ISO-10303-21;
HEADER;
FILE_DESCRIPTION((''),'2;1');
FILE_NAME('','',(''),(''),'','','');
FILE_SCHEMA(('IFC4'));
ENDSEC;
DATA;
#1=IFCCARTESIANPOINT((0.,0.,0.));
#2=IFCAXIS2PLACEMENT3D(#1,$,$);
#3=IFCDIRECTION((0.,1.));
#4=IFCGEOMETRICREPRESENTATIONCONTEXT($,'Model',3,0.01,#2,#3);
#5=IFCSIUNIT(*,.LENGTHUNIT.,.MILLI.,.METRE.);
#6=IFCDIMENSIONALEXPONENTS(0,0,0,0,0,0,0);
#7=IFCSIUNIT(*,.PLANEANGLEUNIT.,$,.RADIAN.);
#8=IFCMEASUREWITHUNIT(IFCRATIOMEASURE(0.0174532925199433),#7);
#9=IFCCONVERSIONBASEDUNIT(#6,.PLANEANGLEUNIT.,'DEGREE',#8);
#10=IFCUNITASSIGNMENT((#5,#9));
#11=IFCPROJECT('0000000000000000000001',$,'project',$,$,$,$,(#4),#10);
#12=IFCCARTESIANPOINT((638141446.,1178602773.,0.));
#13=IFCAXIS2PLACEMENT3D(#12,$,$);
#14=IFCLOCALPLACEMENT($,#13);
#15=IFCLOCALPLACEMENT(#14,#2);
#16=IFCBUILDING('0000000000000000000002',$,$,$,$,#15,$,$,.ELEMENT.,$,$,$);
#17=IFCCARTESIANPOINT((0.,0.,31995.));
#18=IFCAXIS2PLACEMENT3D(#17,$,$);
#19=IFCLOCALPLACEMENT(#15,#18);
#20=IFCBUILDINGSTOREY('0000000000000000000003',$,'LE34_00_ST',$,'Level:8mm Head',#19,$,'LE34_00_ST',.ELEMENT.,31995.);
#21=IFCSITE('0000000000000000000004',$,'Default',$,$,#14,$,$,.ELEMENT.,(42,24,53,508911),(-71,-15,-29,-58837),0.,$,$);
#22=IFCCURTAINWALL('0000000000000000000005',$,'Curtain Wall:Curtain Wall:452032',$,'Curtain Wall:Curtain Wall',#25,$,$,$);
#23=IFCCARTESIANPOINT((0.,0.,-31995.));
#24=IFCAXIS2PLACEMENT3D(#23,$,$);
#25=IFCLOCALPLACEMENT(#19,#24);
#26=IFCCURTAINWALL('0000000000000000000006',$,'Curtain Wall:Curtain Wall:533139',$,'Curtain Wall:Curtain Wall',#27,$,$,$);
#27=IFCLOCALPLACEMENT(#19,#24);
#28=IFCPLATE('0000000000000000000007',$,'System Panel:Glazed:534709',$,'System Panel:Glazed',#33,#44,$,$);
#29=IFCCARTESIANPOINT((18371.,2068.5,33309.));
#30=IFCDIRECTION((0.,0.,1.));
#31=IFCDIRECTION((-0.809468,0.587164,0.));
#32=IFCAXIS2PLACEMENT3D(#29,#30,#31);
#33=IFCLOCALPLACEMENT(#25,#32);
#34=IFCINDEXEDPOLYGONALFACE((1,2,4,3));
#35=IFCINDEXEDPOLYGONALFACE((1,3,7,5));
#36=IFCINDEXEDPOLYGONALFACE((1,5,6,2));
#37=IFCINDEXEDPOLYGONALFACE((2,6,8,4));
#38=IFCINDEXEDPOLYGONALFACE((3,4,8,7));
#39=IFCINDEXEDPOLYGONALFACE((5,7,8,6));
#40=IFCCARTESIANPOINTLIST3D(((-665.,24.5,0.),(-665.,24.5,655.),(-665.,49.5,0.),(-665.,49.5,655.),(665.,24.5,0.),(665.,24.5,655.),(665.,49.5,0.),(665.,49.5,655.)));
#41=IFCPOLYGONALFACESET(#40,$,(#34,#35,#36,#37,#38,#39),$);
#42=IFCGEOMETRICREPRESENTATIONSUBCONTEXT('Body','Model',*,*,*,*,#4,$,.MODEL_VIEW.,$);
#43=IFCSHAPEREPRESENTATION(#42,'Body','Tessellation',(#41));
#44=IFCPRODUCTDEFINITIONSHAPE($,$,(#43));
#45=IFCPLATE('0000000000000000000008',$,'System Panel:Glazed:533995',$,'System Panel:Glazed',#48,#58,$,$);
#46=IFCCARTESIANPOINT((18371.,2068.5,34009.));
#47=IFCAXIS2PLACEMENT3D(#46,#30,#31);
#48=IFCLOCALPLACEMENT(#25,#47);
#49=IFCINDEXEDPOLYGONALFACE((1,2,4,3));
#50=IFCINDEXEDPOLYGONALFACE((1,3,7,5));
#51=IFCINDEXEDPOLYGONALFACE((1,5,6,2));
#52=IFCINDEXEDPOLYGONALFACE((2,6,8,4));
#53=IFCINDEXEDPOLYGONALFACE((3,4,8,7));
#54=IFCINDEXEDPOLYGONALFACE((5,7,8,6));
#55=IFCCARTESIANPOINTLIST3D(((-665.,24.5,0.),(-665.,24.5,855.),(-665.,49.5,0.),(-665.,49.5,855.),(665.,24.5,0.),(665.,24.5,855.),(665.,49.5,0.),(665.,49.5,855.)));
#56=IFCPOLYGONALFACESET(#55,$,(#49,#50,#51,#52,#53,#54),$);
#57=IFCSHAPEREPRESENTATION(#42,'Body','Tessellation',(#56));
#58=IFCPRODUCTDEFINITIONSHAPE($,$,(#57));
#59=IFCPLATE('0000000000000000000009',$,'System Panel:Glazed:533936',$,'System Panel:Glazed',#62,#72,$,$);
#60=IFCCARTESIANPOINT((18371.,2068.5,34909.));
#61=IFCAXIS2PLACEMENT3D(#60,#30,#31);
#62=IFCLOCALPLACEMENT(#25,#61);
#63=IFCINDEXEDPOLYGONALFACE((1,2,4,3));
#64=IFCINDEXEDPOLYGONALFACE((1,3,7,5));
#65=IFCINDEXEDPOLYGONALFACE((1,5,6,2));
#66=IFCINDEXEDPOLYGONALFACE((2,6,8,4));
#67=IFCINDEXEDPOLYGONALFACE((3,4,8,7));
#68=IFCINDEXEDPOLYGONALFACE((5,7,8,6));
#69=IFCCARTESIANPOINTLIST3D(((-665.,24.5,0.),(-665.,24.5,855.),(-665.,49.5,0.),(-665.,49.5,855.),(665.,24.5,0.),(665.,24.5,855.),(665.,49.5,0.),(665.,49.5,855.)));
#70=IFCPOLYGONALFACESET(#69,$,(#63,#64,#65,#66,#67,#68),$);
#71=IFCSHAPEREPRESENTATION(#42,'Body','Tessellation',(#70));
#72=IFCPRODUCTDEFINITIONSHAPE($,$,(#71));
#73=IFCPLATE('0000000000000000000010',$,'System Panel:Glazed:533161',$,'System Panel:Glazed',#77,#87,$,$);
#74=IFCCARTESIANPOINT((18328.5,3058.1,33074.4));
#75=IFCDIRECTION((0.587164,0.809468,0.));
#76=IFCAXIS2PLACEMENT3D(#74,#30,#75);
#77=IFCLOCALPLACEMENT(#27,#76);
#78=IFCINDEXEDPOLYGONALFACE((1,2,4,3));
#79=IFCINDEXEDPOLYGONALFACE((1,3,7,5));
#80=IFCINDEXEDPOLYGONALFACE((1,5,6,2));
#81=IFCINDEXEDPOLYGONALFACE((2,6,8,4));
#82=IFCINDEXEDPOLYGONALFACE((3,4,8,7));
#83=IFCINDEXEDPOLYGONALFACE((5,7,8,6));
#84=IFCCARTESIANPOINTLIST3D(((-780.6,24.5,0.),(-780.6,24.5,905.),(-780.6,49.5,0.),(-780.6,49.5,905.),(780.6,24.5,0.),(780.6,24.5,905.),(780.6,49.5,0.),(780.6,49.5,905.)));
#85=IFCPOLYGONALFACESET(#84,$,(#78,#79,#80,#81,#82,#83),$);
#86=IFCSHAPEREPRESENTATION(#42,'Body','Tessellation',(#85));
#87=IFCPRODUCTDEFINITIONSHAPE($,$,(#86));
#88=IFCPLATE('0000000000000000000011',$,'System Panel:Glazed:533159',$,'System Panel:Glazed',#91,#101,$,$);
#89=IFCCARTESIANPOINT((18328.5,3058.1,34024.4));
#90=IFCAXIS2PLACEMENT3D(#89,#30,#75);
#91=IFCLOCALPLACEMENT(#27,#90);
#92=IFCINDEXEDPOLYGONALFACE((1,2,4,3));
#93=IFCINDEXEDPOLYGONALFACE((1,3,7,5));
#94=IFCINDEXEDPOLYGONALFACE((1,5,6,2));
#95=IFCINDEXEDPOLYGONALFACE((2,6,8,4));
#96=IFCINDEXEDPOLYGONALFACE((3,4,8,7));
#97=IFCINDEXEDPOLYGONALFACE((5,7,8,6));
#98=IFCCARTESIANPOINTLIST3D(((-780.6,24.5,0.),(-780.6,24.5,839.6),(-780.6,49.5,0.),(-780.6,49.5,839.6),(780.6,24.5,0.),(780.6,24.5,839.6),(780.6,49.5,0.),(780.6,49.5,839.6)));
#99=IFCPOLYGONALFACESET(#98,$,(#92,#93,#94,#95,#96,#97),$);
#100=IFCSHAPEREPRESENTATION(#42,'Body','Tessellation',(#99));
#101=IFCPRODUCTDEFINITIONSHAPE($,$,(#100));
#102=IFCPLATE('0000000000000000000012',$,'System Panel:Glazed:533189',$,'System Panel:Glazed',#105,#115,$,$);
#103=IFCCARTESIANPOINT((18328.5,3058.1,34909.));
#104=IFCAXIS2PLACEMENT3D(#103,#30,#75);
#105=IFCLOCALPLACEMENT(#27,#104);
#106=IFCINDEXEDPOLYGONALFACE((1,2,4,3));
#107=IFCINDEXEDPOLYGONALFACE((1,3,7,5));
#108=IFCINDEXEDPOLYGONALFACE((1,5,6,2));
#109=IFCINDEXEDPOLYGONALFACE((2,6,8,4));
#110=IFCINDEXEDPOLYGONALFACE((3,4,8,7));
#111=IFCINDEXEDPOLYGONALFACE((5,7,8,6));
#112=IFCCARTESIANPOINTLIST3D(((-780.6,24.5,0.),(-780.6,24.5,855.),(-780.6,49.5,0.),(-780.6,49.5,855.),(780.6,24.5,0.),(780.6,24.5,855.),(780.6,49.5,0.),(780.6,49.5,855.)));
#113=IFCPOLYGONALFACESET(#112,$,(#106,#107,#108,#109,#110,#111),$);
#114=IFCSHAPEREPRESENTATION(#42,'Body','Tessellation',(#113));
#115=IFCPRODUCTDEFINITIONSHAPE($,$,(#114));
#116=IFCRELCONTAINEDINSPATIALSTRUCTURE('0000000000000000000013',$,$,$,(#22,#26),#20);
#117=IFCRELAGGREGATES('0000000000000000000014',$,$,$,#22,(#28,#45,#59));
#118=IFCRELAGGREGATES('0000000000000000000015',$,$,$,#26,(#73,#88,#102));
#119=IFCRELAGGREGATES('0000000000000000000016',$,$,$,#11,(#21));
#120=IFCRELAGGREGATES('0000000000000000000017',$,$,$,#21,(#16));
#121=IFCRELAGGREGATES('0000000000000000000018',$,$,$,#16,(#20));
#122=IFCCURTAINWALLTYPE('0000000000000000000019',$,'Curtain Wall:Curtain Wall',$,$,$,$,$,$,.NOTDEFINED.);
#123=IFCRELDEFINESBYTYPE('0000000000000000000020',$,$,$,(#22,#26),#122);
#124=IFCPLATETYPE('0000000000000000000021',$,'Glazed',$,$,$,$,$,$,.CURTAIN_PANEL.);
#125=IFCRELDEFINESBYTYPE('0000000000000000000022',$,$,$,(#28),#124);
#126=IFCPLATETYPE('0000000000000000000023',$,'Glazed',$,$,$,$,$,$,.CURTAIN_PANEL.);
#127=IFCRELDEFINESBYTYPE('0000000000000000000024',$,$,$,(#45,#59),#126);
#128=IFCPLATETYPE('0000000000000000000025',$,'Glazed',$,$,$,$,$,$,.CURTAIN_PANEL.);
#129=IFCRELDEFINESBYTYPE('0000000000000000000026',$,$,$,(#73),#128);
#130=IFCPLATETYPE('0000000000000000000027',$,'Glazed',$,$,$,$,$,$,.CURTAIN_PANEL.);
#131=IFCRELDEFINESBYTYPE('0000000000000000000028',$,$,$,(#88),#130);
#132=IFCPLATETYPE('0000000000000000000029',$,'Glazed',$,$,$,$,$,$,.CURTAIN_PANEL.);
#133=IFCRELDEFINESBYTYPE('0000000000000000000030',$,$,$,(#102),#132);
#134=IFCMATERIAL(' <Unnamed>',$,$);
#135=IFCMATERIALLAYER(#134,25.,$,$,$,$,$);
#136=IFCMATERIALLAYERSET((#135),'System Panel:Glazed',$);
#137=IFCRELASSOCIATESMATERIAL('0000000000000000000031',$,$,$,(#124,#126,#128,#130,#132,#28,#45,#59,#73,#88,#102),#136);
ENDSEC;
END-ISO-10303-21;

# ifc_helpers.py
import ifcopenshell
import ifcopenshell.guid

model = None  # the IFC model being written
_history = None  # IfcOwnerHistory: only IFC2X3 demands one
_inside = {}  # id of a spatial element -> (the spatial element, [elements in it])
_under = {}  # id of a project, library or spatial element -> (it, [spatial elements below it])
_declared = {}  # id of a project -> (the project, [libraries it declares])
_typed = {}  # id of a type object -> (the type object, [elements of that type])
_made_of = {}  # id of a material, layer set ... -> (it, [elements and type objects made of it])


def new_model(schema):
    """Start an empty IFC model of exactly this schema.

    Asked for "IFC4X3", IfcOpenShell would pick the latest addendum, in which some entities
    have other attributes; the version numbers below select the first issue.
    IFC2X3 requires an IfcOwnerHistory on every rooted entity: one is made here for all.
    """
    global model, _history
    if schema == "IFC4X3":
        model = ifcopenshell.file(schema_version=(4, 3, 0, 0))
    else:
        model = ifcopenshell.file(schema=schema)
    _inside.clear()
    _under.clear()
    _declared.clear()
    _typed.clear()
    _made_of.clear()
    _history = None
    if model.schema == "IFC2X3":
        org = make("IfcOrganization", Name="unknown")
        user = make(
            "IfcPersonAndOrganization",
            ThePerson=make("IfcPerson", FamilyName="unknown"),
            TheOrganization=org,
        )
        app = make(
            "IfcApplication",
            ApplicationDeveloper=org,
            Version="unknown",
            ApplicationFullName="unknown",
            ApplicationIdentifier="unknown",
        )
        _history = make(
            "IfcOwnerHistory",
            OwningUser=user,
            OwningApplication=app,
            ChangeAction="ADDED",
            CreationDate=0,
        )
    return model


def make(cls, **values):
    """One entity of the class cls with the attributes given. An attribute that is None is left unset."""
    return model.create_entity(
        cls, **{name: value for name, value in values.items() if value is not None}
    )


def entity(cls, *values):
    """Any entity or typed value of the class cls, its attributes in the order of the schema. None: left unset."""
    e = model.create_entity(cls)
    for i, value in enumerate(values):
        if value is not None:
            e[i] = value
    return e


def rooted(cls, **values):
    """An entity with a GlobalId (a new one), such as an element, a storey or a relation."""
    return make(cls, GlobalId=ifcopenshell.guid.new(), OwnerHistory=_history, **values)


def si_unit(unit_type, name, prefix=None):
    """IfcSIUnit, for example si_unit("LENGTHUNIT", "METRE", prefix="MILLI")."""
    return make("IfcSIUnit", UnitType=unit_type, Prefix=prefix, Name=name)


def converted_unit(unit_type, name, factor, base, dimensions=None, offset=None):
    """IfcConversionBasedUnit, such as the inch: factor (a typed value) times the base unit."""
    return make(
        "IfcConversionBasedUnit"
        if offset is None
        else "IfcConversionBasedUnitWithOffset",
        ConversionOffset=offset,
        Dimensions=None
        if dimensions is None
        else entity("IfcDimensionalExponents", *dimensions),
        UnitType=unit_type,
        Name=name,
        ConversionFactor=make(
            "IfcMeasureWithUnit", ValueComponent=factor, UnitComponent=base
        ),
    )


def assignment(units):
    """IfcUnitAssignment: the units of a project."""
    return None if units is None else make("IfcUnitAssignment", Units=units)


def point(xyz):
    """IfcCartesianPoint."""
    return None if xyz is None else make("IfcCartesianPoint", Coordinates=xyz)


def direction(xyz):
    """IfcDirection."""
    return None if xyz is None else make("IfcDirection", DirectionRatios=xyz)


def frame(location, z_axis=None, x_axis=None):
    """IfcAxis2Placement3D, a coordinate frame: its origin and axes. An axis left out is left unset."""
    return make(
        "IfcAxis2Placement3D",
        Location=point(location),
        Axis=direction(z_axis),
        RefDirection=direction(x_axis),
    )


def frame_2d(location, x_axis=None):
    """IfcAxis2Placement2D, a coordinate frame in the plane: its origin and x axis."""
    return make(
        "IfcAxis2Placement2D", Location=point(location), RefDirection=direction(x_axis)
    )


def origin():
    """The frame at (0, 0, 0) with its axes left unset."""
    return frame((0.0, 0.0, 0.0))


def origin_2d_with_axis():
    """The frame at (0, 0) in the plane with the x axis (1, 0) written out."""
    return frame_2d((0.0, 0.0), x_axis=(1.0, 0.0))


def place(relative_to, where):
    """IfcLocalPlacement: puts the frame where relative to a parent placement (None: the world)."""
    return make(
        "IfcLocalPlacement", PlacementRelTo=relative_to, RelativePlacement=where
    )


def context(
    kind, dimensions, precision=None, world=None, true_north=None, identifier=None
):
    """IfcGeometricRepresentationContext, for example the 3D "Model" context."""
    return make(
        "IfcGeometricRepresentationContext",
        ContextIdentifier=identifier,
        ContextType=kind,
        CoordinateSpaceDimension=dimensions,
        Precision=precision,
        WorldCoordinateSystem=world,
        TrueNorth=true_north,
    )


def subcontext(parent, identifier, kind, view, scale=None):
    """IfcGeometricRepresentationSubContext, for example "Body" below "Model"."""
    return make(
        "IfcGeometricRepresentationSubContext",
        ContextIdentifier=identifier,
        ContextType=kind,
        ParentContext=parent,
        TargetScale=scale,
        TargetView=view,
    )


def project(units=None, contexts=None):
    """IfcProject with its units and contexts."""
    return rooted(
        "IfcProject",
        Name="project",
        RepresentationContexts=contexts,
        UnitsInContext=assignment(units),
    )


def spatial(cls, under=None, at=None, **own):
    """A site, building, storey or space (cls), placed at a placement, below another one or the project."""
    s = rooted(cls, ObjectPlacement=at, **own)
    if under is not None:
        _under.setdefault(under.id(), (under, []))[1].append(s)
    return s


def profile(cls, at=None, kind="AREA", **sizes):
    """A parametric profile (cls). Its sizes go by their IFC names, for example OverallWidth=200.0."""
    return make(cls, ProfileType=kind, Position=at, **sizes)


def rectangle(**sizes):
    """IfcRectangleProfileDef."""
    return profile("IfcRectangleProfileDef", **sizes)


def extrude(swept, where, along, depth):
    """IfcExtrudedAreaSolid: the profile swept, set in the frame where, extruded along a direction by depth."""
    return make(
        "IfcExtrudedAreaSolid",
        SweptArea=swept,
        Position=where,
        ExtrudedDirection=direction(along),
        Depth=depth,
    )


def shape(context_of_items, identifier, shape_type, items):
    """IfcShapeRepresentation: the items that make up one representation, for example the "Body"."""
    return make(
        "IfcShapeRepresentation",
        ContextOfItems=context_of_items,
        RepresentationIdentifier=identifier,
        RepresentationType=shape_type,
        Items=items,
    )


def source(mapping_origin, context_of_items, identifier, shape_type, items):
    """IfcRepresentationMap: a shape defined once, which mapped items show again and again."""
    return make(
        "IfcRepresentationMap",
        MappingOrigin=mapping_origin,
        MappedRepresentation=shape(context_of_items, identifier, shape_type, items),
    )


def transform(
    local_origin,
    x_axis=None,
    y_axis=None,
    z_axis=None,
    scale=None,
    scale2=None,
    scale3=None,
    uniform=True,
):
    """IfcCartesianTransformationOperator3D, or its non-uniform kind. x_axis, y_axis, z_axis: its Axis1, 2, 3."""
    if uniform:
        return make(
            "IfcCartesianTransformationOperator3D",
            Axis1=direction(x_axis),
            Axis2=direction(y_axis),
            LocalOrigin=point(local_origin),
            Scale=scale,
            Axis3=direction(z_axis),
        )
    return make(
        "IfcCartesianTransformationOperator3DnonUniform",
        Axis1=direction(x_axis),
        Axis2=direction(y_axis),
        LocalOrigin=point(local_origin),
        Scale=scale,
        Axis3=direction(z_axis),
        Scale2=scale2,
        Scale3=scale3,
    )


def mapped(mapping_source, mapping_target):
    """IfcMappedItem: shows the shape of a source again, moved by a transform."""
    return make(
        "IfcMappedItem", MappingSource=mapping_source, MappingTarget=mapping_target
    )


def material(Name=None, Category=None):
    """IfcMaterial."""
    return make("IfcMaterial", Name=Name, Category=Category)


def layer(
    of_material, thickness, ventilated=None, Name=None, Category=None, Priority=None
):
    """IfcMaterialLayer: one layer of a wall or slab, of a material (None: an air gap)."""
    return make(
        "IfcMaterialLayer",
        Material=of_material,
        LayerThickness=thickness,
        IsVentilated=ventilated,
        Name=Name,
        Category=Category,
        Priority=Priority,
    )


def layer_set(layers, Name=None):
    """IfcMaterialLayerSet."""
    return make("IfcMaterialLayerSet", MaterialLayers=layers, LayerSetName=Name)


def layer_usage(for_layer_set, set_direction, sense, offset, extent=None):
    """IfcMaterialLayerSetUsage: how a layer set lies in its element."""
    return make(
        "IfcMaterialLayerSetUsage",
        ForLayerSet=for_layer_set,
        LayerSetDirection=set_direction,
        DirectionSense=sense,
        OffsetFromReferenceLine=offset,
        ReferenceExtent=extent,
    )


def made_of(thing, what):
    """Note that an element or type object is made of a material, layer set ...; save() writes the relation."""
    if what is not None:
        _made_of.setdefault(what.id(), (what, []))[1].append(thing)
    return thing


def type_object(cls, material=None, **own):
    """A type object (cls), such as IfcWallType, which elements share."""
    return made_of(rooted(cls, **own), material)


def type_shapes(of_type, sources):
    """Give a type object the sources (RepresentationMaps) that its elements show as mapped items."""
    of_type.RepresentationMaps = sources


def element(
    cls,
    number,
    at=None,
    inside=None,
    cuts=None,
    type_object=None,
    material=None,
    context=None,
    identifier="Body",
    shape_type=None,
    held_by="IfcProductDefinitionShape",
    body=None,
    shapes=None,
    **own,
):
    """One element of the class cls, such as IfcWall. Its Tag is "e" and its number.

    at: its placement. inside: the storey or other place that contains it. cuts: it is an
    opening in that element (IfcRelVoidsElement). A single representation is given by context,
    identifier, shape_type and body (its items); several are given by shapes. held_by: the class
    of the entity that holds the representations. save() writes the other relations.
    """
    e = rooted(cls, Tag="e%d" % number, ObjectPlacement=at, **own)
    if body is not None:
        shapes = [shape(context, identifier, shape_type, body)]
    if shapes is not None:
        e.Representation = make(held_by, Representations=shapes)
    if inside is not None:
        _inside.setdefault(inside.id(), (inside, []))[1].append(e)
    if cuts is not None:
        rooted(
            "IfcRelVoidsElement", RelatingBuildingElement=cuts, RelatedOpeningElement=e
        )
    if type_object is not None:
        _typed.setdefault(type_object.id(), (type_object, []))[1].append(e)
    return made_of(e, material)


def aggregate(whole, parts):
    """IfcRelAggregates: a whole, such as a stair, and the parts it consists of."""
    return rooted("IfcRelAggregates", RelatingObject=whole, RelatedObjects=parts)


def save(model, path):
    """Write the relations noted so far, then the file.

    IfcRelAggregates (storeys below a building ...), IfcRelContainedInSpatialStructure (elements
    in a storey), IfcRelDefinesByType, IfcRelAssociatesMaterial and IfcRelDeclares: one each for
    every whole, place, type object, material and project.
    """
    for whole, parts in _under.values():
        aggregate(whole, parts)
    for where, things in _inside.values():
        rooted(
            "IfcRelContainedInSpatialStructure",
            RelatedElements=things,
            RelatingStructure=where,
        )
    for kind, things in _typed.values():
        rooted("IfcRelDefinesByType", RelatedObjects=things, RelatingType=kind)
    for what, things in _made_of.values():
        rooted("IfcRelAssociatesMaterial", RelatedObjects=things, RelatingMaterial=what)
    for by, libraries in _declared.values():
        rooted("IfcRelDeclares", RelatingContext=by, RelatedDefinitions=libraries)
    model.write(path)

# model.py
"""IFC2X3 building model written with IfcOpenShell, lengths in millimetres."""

from ifc_helpers import new_model, entity, si_unit, converted_unit, direction, frame, frame_2d, origin, origin_2d_with_axis, place, context, subcontext, project, spatial, rectangle, extrude, source, transform, mapped, material, layer, layer_set, layer_usage, type_object, type_shapes, element, aggregate, save


model = new_model("IFC2X3")

# Units and contexts
model_context = context("Model", 3, precision=0.01, world=origin(), true_north=direction((0.0, 1.0)))
body_context = subcontext(model_context, "Body", "Model", "MODEL_VIEW")
ifc_project = project(units=[si_unit("LENGTHUNIT", "METRE", prefix="MILLI"), converted_unit("PLANEANGLEUNIT", "DEGREE", entity("IfcRatioMeasure", 0.0174532925199433), si_unit("PLANEANGLEUNIT", "RADIAN"), dimensions=[0, 0, 0, 0, 0, 0, 0])], contexts=[model_context])

# Site, building, storey
site_placement = place(None, frame((638141446.0, 1178602773.0, 0.0)))
site = spatial("IfcSite", under=ifc_project, at=site_placement, Name="Default", CompositionType="ELEMENT", RefLatitude=(42, 24, 53, 508911), RefLongitude=(-71, -15, -29, -58837), RefElevation=0.0)
building_placement = place(site_placement, origin())
building = spatial("IfcBuilding", under=site, at=building_placement, CompositionType="ELEMENT")
storey_placement = place(building_placement, frame((0.0, 0.0, 31995.0)))
storey = spatial("IfcBuildingStorey", under=building, at=storey_placement, Name="LE34_00_ST", ObjectType="Level:8mm Head", LongName="LE34_00_ST", CompositionType="ELEMENT", Elevation=31995.0)

# Curtain walls
curtain_wall_type = type_object("IfcCurtainWallType", Name="Curtain Wall:Curtain Wall", PredefinedType="NOTDEFINED")
curtain_wall_1_placement = place(storey_placement, frame((0.0, 0.0, -31995.0)))
curtain_wall_1 = element("IfcCurtainWall", 1, at=curtain_wall_1_placement, inside=storey, type_object=curtain_wall_type, Name="Curtain Wall:Curtain Wall:452032", ObjectType="Curtain Wall:Curtain Wall")
curtain_wall_2_placement = place(storey_placement, frame((0.0, 0.0, -31995.0)))
curtain_wall_2 = element("IfcCurtainWall", 2, at=curtain_wall_2_placement, inside=storey, type_object=curtain_wall_type, Name="Curtain Wall:Curtain Wall:533139", ObjectType="Curtain Wall:Curtain Wall")

# Plates
ifc_material_1 = material(Name=" <Unnamed>")
ifc_layer = layer(ifc_material_1, 25.0)
ifc_layer_set = layer_set([ifc_layer], Name="System Panel:Glazed")
ifc_layer_usage_1 = layer_usage(ifc_layer_set, "AXIS3", "POSITIVE", 0.1)
plate_type_1 = type_object("IfcPlateType", Name="Glazed", PredefinedType="CURTAIN_PANEL", material=ifc_layer_set)
shared_shape_1 = source(origin(), body_context, "Body", "SweptSolid", [
    extrude(rectangle(XDim=25.0, YDim=1330.0, at=origin_2d_with_axis()), frame((0.0, 37.0, 0.0), z_axis=(0.0, 0.0, 1.0), x_axis=(0.0, 1.0, 0.0)), (0.0, 0.0, 1.0), 655.0),
])
type_shapes(plate_type_1, [shared_shape_1])
plate_1_placement = place(curtain_wall_1_placement, frame((18371.0, 2068.5, 33309.0), z_axis=(0.0, 0.0, 1.0), x_axis=(-0.809468, 0.587164, 0.0)))
plate_1 = element("IfcPlate", 3, at=plate_1_placement, type_object=plate_type_1, material=ifc_layer_usage_1, Name="System Panel:Glazed:534709", ObjectType="System Panel:Glazed", context=body_context, shape_type="MappedRepresentation", body=[
    mapped(shared_shape_1, transform((0.0, 0.0, 0.0), scale=1.0)),
])
ifc_layer_usage_2 = layer_usage(ifc_layer_set, "AXIS3", "POSITIVE", 0.1)
plate_type_2 = type_object("IfcPlateType", Name="Glazed", PredefinedType="CURTAIN_PANEL", material=ifc_layer_set)
shared_shape_2 = source(origin(), body_context, "Body", "SweptSolid", [
    extrude(rectangle(XDim=25.0, YDim=1330.0, at=origin_2d_with_axis()), frame((0.0, 37.0, 0.0), z_axis=(0.0, 0.0, 1.0), x_axis=(0.0, 1.0, 0.0)), (0.0, 0.0, 1.0), 855.0),
])
type_shapes(plate_type_2, [shared_shape_2])
plate_2_placement = place(curtain_wall_1_placement, frame((18371.0, 2068.5, 34009.0), z_axis=(0.0, 0.0, 1.0), x_axis=(-0.809468, 0.587164, 0.0)))
plate_2 = element("IfcPlate", 4, at=plate_2_placement, type_object=plate_type_2, material=ifc_layer_usage_2, Name="System Panel:Glazed:533995", ObjectType="System Panel:Glazed", context=body_context, shape_type="MappedRepresentation", body=[
    mapped(shared_shape_2, transform((0.0, 0.0, 0.0), scale=1.0)),
])
ifc_layer_usage_3 = layer_usage(ifc_layer_set, "AXIS3", "POSITIVE", 0.1)
plate_3_placement = place(curtain_wall_1_placement, frame((18371.0, 2068.5, 34909.0), z_axis=(0.0, 0.0, 1.0), x_axis=(-0.809468, 0.587164, 0.0)))
plate_3 = element("IfcPlate", 5, at=plate_3_placement, type_object=plate_type_2, material=ifc_layer_usage_3, Name="System Panel:Glazed:533936", ObjectType="System Panel:Glazed", context=body_context, shape_type="MappedRepresentation", body=[
    mapped(shared_shape_2, transform((0.0, 0.0, 0.0), scale=1.0)),
])
aggregate(curtain_wall_1, [plate_1, plate_2, plate_3])
ifc_layer_usage_4 = layer_usage(ifc_layer_set, "AXIS3", "POSITIVE", 0.1)
plate_type_3 = type_object("IfcPlateType", Name="Glazed", PredefinedType="CURTAIN_PANEL", material=ifc_layer_set)
shared_shape_3 = source(origin(), body_context, "Body", "SweptSolid", [
    extrude(rectangle(XDim=25.0, YDim=1561.3, at=frame_2d((0.0, 0.0), x_axis=(1.0, 0.0))), frame((0.0, 37.0, 0.0), z_axis=(0.0, 0.0, 1.0), x_axis=(0.0, 1.0, 0.0)), (0.0, 0.0, 1.0), 905.0),
])
type_shapes(plate_type_3, [shared_shape_3])
plate_4_placement = place(curtain_wall_2_placement, frame((18328.5, 3058.1, 33074.4), z_axis=(0.0, 0.0, 1.0), x_axis=(0.587164, 0.809468, 0.0)))
plate_4 = element("IfcPlate", 6, at=plate_4_placement, type_object=plate_type_3, material=ifc_layer_usage_4, Name="System Panel:Glazed:533161", ObjectType="System Panel:Glazed", context=body_context, shape_type="MappedRepresentation", body=[
    mapped(shared_shape_3, transform((0.0, 0.0, 0.0), scale=1.0)),
])
ifc_layer_usage_5 = layer_usage(ifc_layer_set, "AXIS3", "POSITIVE", 0.1)
plate_type_4 = type_object("IfcPlateType", Name="Glazed", PredefinedType="CURTAIN_PANEL", material=ifc_layer_set)
shared_shape_4 = source(origin(), body_context, "Body", "SweptSolid", [
    extrude(rectangle(XDim=25.0, YDim=1561.3, at=origin_2d_with_axis()), frame((0.0, 37.0, 0.0), z_axis=(0.0, 0.0, 1.0), x_axis=(0.0, 1.0, 0.0)), (0.0, 0.0, 1.0), 839.6),
])
type_shapes(plate_type_4, [shared_shape_4])
plate_5_placement = place(curtain_wall_2_placement, frame((18328.5, 3058.1, 34024.4), z_axis=(0.0, 0.0, 1.0), x_axis=(0.587164, 0.809468, 0.0)))
plate_5 = element("IfcPlate", 7, at=plate_5_placement, type_object=plate_type_4, material=ifc_layer_usage_5, Name="System Panel:Glazed:533159", ObjectType="System Panel:Glazed", context=body_context, shape_type="MappedRepresentation", body=[
    mapped(shared_shape_4, transform((0.0, 0.0, 0.0), scale=1.0)),
])
ifc_layer_usage_6 = layer_usage(ifc_layer_set, "AXIS3", "POSITIVE", 0.1)
plate_type_5 = type_object("IfcPlateType", Name="Glazed", PredefinedType="CURTAIN_PANEL", material=ifc_layer_set)
shared_shape_5 = source(origin(), body_context, "Body", "SweptSolid", [
    extrude(rectangle(XDim=25.0, YDim=1561.3, at=origin_2d_with_axis()), frame((0.0, 37.0, 0.0), z_axis=(0.0, 0.0, 1.0), x_axis=(0.0, 1.0, 0.0)), (0.0, 0.0, 1.0), 855.0),
])
type_shapes(plate_type_5, [shared_shape_5])
plate_6_placement = place(curtain_wall_2_placement, frame((18328.5, 3058.1, 34909.0), z_axis=(0.0, 0.0, 1.0), x_axis=(0.587164, 0.809468, 0.0)))
plate_6 = element("IfcPlate", 8, at=plate_6_placement, type_object=plate_type_5, material=ifc_layer_usage_6, Name="System Panel:Glazed:533189", ObjectType="System Panel:Glazed", context=body_context, shape_type="MappedRepresentation", body=[
    mapped(shared_shape_5, transform((0.0, 0.0, 0.0), scale=1.0)),
])
aggregate(curtain_wall_2, [plate_4, plate_5, plate_6])

save(model, "model.ifc")
